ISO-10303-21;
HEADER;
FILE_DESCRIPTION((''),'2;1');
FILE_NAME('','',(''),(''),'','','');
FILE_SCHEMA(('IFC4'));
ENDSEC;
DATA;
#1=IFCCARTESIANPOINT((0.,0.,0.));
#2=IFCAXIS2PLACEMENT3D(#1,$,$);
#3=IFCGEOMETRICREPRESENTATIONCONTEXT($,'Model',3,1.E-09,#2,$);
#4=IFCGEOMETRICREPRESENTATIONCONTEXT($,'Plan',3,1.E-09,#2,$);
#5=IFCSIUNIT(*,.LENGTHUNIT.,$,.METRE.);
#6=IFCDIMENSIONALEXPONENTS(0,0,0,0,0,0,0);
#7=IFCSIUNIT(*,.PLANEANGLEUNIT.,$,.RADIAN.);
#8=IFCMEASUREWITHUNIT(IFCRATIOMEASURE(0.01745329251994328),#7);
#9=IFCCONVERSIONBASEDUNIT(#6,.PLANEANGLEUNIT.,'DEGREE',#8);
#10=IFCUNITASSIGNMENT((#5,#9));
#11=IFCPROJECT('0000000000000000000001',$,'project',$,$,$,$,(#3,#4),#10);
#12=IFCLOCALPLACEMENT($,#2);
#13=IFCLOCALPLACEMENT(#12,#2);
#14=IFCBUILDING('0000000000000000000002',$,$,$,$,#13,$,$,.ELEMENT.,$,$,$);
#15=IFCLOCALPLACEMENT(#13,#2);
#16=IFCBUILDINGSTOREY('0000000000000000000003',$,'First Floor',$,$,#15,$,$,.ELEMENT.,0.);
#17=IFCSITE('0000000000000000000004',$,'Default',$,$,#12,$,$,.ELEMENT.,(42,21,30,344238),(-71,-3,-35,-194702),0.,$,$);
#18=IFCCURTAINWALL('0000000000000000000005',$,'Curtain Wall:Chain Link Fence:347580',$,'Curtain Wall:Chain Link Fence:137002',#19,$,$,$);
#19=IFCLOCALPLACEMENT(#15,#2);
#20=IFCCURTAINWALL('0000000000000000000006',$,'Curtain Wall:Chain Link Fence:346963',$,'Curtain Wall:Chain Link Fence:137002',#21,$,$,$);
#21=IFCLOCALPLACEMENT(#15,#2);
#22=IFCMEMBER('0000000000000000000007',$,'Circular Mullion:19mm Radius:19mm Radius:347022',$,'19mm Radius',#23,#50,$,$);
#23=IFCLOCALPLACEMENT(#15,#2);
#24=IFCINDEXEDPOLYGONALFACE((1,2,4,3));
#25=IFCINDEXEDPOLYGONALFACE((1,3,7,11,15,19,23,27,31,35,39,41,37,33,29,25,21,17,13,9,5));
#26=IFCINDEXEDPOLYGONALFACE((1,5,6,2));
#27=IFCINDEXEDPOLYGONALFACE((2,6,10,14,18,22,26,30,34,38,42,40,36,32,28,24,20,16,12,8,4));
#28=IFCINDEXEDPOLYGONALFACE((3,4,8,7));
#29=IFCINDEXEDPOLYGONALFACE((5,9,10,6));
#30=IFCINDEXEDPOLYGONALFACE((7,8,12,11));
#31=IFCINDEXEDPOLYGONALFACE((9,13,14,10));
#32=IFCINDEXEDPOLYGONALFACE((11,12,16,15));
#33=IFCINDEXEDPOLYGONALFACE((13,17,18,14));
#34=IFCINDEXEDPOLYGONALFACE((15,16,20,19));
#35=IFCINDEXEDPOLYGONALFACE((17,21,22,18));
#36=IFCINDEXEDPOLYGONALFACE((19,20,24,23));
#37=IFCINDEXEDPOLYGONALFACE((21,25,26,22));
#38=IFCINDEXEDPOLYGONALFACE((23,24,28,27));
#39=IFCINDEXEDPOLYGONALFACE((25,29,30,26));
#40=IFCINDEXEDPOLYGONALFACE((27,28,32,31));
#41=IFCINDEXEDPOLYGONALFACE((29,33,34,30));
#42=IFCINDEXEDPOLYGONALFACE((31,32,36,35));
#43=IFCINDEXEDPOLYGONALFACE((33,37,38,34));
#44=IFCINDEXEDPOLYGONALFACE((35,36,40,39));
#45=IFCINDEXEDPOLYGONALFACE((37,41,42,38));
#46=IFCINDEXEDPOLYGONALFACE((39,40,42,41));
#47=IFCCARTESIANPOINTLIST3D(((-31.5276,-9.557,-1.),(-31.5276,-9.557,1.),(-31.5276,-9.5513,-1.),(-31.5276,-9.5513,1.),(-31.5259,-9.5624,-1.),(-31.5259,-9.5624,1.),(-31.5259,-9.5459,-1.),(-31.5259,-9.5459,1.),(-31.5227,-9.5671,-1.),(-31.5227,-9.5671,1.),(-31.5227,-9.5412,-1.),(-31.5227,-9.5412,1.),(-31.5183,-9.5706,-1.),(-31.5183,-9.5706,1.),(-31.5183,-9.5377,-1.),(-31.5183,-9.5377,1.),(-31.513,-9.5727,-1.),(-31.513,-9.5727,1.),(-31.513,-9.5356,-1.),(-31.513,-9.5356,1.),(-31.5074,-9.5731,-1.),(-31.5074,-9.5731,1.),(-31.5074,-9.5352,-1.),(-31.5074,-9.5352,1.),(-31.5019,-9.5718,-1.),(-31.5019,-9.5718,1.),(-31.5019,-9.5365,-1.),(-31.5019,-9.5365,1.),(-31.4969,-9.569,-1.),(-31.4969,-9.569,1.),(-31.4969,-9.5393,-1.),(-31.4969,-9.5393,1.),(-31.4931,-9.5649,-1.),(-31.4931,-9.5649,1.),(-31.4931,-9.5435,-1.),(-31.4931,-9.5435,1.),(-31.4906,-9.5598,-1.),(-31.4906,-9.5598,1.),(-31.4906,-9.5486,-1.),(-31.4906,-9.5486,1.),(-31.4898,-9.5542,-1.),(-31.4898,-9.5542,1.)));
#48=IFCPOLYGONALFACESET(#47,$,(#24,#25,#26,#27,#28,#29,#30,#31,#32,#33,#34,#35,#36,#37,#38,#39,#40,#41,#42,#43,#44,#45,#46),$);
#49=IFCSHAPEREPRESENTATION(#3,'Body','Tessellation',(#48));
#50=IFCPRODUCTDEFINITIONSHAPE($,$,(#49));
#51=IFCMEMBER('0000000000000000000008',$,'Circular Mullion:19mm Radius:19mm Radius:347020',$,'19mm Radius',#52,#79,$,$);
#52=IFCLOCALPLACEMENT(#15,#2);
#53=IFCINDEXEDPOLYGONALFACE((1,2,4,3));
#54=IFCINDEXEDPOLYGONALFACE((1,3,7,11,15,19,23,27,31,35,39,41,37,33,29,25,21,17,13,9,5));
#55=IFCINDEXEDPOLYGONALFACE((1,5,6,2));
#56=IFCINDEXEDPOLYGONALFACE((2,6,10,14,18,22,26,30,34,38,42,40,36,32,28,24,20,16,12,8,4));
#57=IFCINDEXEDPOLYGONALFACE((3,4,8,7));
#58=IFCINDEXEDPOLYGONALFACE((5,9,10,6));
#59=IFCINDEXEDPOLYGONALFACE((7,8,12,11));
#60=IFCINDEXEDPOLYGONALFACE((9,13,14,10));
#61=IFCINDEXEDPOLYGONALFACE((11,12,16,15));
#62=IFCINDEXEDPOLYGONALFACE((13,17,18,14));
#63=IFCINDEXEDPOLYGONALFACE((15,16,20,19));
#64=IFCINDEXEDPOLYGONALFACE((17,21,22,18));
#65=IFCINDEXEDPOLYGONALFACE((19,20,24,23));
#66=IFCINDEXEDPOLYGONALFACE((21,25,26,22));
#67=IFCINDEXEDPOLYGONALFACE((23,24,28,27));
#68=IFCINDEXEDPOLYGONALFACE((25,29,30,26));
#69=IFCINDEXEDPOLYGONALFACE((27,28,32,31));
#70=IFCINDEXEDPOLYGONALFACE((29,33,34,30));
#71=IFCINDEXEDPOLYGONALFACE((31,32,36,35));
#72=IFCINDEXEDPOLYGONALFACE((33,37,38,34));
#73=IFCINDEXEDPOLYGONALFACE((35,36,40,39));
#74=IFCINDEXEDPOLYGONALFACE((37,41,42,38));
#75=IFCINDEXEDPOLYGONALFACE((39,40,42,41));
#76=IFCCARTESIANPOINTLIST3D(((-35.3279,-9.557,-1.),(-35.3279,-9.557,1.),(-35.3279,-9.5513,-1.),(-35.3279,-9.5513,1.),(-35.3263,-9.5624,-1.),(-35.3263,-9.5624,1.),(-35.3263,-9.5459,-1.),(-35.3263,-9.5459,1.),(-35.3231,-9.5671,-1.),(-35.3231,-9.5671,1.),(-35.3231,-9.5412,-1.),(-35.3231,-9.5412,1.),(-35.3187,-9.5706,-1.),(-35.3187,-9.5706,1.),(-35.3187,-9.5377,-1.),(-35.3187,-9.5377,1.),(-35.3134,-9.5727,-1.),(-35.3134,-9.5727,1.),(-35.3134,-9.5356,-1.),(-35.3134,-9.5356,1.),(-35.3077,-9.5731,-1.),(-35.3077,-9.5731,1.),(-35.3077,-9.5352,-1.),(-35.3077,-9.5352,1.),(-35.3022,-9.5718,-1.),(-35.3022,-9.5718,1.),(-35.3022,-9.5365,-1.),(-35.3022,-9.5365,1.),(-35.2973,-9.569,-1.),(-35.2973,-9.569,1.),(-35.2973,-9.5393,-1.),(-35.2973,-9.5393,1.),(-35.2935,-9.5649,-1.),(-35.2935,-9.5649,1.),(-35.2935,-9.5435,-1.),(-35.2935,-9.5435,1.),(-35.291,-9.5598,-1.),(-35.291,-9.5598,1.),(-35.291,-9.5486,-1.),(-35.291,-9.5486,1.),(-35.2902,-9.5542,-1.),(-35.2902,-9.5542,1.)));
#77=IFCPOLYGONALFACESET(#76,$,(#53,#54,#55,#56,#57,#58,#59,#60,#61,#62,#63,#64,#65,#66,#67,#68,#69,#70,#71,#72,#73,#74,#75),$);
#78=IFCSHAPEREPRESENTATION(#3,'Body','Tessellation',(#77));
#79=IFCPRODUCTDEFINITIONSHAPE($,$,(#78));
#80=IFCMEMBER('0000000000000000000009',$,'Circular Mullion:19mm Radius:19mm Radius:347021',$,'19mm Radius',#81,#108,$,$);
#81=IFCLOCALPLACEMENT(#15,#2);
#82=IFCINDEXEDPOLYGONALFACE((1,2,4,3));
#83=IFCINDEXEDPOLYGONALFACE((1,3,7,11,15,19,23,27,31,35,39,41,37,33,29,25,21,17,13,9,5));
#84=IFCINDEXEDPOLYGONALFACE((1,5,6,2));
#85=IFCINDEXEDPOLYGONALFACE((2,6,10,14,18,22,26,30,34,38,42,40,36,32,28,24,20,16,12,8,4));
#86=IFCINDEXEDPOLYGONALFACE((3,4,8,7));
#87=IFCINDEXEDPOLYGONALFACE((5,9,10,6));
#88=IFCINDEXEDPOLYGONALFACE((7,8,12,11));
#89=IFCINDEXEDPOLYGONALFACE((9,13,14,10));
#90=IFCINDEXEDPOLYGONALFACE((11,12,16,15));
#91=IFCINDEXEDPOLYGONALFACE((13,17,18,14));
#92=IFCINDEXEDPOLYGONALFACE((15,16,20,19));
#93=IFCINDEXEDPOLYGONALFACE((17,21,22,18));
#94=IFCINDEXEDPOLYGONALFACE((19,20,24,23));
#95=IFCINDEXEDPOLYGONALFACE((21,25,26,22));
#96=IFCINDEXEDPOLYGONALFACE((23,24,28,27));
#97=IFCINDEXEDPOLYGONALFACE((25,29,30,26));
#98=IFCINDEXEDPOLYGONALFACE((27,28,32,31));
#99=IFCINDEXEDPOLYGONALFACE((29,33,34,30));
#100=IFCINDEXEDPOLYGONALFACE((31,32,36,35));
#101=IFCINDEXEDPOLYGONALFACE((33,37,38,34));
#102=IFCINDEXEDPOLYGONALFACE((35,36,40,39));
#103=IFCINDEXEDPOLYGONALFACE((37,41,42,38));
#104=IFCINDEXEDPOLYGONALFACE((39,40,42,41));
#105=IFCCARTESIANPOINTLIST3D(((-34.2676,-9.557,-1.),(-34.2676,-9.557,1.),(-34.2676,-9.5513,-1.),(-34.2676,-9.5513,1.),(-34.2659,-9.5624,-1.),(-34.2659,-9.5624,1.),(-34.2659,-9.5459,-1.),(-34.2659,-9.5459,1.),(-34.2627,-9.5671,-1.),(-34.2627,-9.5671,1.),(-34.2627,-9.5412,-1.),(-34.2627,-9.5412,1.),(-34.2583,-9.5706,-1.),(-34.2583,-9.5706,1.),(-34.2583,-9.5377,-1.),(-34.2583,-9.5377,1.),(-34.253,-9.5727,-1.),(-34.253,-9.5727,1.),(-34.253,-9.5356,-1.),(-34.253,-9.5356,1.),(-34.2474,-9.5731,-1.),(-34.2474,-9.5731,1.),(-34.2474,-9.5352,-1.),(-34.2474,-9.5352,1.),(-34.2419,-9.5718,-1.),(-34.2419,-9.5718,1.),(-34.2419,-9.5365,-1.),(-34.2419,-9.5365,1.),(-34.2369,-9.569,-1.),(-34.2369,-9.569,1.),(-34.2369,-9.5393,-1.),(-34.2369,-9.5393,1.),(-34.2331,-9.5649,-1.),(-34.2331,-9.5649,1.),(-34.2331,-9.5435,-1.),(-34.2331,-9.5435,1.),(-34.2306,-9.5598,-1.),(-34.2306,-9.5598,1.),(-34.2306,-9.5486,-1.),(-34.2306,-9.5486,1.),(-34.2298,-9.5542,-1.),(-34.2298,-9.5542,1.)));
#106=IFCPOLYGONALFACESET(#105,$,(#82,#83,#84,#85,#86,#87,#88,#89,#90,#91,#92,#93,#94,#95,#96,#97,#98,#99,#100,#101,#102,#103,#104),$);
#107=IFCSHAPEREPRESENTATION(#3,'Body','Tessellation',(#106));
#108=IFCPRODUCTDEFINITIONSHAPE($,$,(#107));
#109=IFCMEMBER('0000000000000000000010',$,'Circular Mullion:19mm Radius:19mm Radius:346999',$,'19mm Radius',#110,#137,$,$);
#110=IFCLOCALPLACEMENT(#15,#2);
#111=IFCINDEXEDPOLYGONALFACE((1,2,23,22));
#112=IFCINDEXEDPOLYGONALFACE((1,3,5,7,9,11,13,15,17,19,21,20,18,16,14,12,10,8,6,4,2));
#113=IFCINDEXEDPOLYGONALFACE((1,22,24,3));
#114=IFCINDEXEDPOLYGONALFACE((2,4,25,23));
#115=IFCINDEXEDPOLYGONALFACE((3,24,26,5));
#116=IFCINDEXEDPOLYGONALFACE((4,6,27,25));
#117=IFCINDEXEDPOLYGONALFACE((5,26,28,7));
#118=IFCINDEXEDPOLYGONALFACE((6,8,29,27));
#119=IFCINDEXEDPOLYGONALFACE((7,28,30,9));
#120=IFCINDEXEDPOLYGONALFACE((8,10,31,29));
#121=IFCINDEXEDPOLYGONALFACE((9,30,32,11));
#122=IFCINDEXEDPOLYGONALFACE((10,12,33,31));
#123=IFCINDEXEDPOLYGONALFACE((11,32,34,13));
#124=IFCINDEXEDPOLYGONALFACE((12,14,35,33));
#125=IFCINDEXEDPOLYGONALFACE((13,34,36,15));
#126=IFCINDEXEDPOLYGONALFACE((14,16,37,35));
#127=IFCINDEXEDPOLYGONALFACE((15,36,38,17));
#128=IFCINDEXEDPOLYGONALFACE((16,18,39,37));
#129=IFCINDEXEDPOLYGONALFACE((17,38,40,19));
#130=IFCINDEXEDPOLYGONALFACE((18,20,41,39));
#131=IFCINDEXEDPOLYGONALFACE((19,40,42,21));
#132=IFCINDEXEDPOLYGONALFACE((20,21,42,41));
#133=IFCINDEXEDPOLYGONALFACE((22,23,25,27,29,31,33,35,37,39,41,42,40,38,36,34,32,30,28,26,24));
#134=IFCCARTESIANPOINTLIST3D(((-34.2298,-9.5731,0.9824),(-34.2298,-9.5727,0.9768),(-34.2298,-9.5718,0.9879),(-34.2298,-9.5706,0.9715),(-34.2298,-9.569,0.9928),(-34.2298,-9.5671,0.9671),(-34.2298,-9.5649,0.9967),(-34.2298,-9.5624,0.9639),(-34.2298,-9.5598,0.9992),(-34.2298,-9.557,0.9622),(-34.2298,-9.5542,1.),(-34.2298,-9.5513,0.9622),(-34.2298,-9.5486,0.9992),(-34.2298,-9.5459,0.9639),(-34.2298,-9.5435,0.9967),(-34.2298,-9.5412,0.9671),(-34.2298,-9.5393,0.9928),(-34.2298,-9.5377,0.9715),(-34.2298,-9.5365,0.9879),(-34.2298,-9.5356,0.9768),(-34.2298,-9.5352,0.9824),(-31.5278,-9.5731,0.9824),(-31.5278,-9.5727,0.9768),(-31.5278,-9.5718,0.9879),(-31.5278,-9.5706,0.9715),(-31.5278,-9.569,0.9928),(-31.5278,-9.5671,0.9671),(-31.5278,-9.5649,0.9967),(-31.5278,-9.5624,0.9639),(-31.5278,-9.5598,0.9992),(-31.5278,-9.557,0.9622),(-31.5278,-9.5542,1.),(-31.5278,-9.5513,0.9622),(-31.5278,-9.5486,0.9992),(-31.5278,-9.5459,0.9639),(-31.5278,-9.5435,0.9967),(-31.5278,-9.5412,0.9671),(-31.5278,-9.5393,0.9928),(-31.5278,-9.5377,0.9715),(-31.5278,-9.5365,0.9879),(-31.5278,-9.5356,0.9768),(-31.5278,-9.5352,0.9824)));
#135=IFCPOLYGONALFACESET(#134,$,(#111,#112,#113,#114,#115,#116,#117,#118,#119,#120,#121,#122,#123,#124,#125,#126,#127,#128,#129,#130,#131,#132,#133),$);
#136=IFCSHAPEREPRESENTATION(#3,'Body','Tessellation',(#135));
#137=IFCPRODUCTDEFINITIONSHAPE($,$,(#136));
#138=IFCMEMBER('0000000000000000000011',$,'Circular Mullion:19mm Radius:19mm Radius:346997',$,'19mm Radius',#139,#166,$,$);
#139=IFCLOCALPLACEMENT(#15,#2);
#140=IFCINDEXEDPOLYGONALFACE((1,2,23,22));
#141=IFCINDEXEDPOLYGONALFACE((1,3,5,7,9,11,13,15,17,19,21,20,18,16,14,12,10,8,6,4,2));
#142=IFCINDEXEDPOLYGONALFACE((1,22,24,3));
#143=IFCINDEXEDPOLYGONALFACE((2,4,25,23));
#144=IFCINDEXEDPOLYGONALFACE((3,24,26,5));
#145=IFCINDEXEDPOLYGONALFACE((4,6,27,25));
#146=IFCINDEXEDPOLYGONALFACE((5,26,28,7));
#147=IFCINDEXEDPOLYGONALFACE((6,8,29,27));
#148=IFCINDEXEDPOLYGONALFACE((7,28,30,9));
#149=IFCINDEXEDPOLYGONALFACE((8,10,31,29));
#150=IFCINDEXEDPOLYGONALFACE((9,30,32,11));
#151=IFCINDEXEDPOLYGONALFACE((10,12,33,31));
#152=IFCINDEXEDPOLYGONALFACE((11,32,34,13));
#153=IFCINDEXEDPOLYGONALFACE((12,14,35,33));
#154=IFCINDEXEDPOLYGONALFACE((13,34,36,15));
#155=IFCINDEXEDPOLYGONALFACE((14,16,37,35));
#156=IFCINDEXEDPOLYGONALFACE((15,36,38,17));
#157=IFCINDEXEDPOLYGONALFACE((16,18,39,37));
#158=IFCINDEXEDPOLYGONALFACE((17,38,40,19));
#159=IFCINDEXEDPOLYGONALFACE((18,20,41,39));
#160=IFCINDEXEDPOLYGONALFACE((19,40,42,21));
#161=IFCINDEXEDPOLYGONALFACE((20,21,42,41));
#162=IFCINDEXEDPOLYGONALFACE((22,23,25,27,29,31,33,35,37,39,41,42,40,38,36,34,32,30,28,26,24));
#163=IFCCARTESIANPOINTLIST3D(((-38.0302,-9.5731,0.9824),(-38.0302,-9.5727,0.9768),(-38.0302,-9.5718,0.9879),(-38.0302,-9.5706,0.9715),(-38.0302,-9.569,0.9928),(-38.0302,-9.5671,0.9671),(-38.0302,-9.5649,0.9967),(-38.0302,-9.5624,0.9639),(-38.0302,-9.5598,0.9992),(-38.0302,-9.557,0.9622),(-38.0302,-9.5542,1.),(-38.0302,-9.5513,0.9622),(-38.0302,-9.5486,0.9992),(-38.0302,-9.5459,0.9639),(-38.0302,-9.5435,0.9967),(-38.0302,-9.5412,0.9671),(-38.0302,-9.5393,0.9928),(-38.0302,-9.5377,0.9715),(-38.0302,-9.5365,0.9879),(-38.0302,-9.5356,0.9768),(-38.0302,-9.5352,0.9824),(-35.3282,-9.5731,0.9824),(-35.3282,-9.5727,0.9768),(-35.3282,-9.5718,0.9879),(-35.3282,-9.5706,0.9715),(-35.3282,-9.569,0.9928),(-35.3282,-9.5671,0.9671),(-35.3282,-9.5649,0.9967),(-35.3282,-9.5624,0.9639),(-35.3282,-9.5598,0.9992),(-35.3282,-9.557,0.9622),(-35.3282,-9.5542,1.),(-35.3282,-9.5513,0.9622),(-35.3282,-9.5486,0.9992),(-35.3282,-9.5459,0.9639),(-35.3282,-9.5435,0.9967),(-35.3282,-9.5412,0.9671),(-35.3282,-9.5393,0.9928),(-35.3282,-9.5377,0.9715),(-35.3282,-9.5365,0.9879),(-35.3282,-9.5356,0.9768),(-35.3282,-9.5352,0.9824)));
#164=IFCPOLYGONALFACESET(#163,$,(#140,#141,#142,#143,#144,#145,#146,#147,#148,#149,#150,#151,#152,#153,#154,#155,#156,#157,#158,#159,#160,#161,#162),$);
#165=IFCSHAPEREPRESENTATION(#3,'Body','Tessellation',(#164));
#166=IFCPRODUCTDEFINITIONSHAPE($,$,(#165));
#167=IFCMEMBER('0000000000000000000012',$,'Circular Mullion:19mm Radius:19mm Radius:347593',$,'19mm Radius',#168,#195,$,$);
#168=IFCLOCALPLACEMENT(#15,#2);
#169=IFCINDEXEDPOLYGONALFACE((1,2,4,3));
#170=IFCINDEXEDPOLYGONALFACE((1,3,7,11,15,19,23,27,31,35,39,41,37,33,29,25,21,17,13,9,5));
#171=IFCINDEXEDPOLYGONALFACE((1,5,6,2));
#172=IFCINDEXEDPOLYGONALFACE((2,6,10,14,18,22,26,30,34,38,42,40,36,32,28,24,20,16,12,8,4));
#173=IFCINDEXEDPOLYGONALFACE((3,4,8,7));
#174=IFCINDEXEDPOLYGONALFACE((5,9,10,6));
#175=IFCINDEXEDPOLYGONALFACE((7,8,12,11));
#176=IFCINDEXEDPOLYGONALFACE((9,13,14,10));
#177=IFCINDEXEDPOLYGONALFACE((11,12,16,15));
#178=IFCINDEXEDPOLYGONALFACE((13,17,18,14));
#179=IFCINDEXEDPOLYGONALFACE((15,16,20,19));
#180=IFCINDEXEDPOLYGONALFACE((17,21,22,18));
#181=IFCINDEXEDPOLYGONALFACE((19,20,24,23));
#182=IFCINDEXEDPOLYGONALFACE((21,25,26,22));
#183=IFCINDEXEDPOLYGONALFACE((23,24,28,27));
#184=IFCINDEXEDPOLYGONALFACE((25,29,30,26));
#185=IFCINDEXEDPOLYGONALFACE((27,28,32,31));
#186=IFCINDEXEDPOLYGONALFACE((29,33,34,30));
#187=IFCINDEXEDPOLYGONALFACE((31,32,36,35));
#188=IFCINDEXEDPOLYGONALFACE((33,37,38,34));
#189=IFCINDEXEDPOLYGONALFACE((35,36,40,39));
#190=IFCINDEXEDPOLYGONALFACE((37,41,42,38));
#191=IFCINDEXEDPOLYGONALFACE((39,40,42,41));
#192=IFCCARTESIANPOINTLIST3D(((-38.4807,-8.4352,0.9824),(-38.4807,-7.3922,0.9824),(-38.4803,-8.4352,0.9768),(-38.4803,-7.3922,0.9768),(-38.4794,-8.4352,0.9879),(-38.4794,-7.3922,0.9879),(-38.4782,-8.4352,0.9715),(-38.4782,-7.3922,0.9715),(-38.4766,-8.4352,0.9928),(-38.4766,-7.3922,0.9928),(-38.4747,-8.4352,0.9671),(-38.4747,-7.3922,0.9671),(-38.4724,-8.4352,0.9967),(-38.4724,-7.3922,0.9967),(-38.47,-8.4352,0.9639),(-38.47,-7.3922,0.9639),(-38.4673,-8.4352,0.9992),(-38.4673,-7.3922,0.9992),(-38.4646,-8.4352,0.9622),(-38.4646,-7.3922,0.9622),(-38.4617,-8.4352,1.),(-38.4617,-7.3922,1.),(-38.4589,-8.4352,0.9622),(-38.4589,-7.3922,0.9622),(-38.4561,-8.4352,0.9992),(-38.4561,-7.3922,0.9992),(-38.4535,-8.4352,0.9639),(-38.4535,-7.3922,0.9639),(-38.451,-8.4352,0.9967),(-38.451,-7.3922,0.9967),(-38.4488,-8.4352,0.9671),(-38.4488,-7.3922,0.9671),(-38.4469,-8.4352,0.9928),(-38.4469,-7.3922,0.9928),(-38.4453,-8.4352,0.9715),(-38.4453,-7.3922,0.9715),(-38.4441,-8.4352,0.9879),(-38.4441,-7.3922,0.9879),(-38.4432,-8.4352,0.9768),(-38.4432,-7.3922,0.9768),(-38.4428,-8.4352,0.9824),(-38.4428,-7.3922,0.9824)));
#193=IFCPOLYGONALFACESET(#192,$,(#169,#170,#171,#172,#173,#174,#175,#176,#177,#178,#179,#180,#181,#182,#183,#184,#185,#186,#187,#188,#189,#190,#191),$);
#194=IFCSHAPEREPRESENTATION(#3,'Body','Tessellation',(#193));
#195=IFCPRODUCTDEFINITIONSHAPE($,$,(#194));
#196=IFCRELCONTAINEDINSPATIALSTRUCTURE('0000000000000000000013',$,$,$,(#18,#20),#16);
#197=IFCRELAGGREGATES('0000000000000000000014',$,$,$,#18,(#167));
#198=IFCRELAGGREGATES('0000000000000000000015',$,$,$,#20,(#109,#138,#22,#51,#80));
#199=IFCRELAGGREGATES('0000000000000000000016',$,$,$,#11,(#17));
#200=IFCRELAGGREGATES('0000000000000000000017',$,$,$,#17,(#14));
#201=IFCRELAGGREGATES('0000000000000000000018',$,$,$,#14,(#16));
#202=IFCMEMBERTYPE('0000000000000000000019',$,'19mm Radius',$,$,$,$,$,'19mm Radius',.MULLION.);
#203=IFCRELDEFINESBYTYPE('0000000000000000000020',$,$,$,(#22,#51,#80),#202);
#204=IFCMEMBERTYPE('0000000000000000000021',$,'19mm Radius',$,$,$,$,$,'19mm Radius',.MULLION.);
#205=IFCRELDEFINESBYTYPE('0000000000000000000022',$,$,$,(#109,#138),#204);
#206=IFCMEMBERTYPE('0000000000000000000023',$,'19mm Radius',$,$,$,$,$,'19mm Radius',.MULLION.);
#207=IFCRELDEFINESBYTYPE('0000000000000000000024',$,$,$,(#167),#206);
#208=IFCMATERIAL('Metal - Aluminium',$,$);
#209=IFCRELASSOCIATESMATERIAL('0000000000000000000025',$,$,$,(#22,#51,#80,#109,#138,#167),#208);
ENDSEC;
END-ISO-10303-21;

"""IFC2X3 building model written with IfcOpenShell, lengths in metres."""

from ifc_helpers import new_model, entity, si_unit, converted_unit, frame, origin, origin_2d_with_axis, place, context, project, spatial, circle, extrude, source, transform, mapped, material, type_object, type_shapes, element, aggregate, save


model = new_model("IFC2X3")

# Units and contexts
model_context = context("Model", 3, precision=1e-09, world=origin())
plan_context = context("Plan", 3, precision=1e-09, world=origin())
ifc_project = project(units=[si_unit("LENGTHUNIT", "METRE"), converted_unit("PLANEANGLEUNIT", "DEGREE", entity("IfcRatioMeasure", 0.01745329251994328), si_unit("PLANEANGLEUNIT", "RADIAN"), dimensions=[0, 0, 0, 0, 0, 0, 0])], contexts=[model_context, plan_context])

# Site, building, storey
site_placement = place(None, origin())
site = spatial("IfcSite", under=ifc_project, at=site_placement, Name="Default", CompositionType="ELEMENT", RefLatitude=(42, 21, 30, 344238), RefLongitude=(-71, -3, -35, -194702), RefElevation=0.0)
building_placement = place(site_placement, origin())
building = spatial("IfcBuilding", under=site, at=building_placement, CompositionType="ELEMENT")
storey_placement = place(building_placement, origin())
storey = spatial("IfcBuildingStorey", under=building, at=storey_placement, Name="First Floor", CompositionType="ELEMENT", Elevation=0.0)

# Curtain walls
curtain_wall_1_placement = place(storey_placement, origin())
curtain_wall_1 = element("IfcCurtainWall", 1, at=curtain_wall_1_placement, inside=storey, Name="Curtain Wall:Chain Link Fence:347580", ObjectType="Curtain Wall:Chain Link Fence:137002")
ifc_material_1 = material(Name="Metal - Aluminium")
placement = place(building_placement, frame((0.0, 0.0, -1.0)))
curtain_wall_2_placement = place(storey_placement, origin())
curtain_wall_2 = element("IfcCurtainWall", 2, at=curtain_wall_2_placement, inside=storey, Name="Curtain Wall:Chain Link Fence:346963", ObjectType="Curtain Wall:Chain Link Fence:137002")

# Members
shared_shape_1 = source(origin(), model_context, "Body", "SweptSolid", [
    extrude(circle(Radius=0.019, at=origin_2d_with_axis()), frame((0.0, 0.0, -2.0)), (0.0, 0.0, 1.0), 2.0),
])
member_type_1 = type_object("IfcMemberType", Name="19mm Radius", ElementType="19mm Radius", PredefinedType="MULLION")
type_shapes(member_type_1, [shared_shape_1])
member_1_placement = place(placement, frame((-31.5088, -9.5542, 0.0), z_axis=(0.0, 0.0, -1.0), x_axis=(1.0, 0.0, 0.0)))
member_1 = element("IfcMember", 3, at=member_1_placement, type_object=member_type_1, material=ifc_material_1, Name="Circular Mullion:19mm Radius:19mm Radius:347022", ObjectType="19mm Radius", context=model_context, shape_type="MappedRepresentation", body=[
    mapped(shared_shape_1, transform((0.0, 0.0, 0.0), scale=1.0)),
])
member_2_placement = place(placement, frame((-35.3092, -9.5542, 0.0), z_axis=(0.0, 0.0, -1.0), x_axis=(1.0, 0.0, 0.0)))
member_2 = element("IfcMember", 4, at=member_2_placement, type_object=member_type_1, material=ifc_material_1, Name="Circular Mullion:19mm Radius:19mm Radius:347020", ObjectType="19mm Radius", context=model_context, shape_type="MappedRepresentation", body=[
    mapped(shared_shape_1, transform((0.0, 0.0, 0.0), scale=1.0)),
])
member_3_placement = place(placement, frame((-34.2488, -9.5542, 0.0), z_axis=(0.0, 0.0, -1.0), x_axis=(1.0, 0.0, 0.0)))
member_3 = element("IfcMember", 5, at=member_3_placement, type_object=member_type_1, material=ifc_material_1, Name="Circular Mullion:19mm Radius:19mm Radius:347021", ObjectType="19mm Radius", context=model_context, shape_type="MappedRepresentation", body=[
    mapped(shared_shape_1, transform((0.0, 0.0, 0.0), scale=1.0)),
])
member_type_2 = type_object("IfcMemberType", Name="19mm Radius", ElementType="19mm Radius", PredefinedType="MULLION")
shared_shape_2 = source(origin(), model_context, "Body", "SweptSolid", [
    extrude(circle(Radius=0.019, at=origin_2d_with_axis()), frame((-0.019, 0.0, -2.702)), (0.0, 0.0, 1.0), 2.702),
])
type_shapes(member_type_2, [shared_shape_2])
member_4_placement = place(storey_placement, frame((-31.5278, -9.5542, 1.0), z_axis=(1.0, 0.0, 0.0), x_axis=(0.0, 0.0, 1.0)))
member_4 = element("IfcMember", 6, at=member_4_placement, type_object=member_type_2, material=ifc_material_1, Name="Circular Mullion:19mm Radius:19mm Radius:346999", ObjectType="19mm Radius", context=model_context, shape_type="MappedRepresentation", body=[
    mapped(shared_shape_2, transform((0.0, 0.0, 0.0), scale=1.0)),
])
member_5_placement = place(storey_placement, frame((-35.3282, -9.5542, 1.0), z_axis=(1.0, 0.0, 0.0), x_axis=(0.0, 0.0, 1.0)))
member_5 = element("IfcMember", 7, at=member_5_placement, type_object=member_type_2, material=ifc_material_1, Name="Circular Mullion:19mm Radius:19mm Radius:346997", ObjectType="19mm Radius", context=model_context, shape_type="MappedRepresentation", body=[
    mapped(shared_shape_2, transform((0.0, 0.0, 0.0), scale=1.0)),
])
member_type_3 = type_object("IfcMemberType", Name="19mm Radius", ElementType="19mm Radius", PredefinedType="MULLION")
shared_shape_3 = source(origin(), model_context, "Body", "SweptSolid", [
    extrude(circle(Radius=0.019, at=origin_2d_with_axis()), frame((-0.019, 0.0, -1.043)), (0.0, 0.0, 1.0), 1.043),
])
type_shapes(member_type_3, [shared_shape_3])
member_6_placement = place(storey_placement, frame((-38.4617, -7.3922, 1.0), z_axis=(0.0, 1.0, 0.0), x_axis=(0.0, 0.0, 1.0)))
member_6 = element("IfcMember", 8, at=member_6_placement, type_object=member_type_3, material=ifc_material_1, Name="Circular Mullion:19mm Radius:19mm Radius:347593", ObjectType="19mm Radius", context=model_context, shape_type="MappedRepresentation", body=[
    mapped(shared_shape_3, transform((0.0, 0.0, 0.0), scale=1.0)),
])

aggregate(curtain_wall_1, [member_6])
aggregate(curtain_wall_2, [member_4, member_5, member_1, member_2, member_3])

save(model, "model.ifc")
